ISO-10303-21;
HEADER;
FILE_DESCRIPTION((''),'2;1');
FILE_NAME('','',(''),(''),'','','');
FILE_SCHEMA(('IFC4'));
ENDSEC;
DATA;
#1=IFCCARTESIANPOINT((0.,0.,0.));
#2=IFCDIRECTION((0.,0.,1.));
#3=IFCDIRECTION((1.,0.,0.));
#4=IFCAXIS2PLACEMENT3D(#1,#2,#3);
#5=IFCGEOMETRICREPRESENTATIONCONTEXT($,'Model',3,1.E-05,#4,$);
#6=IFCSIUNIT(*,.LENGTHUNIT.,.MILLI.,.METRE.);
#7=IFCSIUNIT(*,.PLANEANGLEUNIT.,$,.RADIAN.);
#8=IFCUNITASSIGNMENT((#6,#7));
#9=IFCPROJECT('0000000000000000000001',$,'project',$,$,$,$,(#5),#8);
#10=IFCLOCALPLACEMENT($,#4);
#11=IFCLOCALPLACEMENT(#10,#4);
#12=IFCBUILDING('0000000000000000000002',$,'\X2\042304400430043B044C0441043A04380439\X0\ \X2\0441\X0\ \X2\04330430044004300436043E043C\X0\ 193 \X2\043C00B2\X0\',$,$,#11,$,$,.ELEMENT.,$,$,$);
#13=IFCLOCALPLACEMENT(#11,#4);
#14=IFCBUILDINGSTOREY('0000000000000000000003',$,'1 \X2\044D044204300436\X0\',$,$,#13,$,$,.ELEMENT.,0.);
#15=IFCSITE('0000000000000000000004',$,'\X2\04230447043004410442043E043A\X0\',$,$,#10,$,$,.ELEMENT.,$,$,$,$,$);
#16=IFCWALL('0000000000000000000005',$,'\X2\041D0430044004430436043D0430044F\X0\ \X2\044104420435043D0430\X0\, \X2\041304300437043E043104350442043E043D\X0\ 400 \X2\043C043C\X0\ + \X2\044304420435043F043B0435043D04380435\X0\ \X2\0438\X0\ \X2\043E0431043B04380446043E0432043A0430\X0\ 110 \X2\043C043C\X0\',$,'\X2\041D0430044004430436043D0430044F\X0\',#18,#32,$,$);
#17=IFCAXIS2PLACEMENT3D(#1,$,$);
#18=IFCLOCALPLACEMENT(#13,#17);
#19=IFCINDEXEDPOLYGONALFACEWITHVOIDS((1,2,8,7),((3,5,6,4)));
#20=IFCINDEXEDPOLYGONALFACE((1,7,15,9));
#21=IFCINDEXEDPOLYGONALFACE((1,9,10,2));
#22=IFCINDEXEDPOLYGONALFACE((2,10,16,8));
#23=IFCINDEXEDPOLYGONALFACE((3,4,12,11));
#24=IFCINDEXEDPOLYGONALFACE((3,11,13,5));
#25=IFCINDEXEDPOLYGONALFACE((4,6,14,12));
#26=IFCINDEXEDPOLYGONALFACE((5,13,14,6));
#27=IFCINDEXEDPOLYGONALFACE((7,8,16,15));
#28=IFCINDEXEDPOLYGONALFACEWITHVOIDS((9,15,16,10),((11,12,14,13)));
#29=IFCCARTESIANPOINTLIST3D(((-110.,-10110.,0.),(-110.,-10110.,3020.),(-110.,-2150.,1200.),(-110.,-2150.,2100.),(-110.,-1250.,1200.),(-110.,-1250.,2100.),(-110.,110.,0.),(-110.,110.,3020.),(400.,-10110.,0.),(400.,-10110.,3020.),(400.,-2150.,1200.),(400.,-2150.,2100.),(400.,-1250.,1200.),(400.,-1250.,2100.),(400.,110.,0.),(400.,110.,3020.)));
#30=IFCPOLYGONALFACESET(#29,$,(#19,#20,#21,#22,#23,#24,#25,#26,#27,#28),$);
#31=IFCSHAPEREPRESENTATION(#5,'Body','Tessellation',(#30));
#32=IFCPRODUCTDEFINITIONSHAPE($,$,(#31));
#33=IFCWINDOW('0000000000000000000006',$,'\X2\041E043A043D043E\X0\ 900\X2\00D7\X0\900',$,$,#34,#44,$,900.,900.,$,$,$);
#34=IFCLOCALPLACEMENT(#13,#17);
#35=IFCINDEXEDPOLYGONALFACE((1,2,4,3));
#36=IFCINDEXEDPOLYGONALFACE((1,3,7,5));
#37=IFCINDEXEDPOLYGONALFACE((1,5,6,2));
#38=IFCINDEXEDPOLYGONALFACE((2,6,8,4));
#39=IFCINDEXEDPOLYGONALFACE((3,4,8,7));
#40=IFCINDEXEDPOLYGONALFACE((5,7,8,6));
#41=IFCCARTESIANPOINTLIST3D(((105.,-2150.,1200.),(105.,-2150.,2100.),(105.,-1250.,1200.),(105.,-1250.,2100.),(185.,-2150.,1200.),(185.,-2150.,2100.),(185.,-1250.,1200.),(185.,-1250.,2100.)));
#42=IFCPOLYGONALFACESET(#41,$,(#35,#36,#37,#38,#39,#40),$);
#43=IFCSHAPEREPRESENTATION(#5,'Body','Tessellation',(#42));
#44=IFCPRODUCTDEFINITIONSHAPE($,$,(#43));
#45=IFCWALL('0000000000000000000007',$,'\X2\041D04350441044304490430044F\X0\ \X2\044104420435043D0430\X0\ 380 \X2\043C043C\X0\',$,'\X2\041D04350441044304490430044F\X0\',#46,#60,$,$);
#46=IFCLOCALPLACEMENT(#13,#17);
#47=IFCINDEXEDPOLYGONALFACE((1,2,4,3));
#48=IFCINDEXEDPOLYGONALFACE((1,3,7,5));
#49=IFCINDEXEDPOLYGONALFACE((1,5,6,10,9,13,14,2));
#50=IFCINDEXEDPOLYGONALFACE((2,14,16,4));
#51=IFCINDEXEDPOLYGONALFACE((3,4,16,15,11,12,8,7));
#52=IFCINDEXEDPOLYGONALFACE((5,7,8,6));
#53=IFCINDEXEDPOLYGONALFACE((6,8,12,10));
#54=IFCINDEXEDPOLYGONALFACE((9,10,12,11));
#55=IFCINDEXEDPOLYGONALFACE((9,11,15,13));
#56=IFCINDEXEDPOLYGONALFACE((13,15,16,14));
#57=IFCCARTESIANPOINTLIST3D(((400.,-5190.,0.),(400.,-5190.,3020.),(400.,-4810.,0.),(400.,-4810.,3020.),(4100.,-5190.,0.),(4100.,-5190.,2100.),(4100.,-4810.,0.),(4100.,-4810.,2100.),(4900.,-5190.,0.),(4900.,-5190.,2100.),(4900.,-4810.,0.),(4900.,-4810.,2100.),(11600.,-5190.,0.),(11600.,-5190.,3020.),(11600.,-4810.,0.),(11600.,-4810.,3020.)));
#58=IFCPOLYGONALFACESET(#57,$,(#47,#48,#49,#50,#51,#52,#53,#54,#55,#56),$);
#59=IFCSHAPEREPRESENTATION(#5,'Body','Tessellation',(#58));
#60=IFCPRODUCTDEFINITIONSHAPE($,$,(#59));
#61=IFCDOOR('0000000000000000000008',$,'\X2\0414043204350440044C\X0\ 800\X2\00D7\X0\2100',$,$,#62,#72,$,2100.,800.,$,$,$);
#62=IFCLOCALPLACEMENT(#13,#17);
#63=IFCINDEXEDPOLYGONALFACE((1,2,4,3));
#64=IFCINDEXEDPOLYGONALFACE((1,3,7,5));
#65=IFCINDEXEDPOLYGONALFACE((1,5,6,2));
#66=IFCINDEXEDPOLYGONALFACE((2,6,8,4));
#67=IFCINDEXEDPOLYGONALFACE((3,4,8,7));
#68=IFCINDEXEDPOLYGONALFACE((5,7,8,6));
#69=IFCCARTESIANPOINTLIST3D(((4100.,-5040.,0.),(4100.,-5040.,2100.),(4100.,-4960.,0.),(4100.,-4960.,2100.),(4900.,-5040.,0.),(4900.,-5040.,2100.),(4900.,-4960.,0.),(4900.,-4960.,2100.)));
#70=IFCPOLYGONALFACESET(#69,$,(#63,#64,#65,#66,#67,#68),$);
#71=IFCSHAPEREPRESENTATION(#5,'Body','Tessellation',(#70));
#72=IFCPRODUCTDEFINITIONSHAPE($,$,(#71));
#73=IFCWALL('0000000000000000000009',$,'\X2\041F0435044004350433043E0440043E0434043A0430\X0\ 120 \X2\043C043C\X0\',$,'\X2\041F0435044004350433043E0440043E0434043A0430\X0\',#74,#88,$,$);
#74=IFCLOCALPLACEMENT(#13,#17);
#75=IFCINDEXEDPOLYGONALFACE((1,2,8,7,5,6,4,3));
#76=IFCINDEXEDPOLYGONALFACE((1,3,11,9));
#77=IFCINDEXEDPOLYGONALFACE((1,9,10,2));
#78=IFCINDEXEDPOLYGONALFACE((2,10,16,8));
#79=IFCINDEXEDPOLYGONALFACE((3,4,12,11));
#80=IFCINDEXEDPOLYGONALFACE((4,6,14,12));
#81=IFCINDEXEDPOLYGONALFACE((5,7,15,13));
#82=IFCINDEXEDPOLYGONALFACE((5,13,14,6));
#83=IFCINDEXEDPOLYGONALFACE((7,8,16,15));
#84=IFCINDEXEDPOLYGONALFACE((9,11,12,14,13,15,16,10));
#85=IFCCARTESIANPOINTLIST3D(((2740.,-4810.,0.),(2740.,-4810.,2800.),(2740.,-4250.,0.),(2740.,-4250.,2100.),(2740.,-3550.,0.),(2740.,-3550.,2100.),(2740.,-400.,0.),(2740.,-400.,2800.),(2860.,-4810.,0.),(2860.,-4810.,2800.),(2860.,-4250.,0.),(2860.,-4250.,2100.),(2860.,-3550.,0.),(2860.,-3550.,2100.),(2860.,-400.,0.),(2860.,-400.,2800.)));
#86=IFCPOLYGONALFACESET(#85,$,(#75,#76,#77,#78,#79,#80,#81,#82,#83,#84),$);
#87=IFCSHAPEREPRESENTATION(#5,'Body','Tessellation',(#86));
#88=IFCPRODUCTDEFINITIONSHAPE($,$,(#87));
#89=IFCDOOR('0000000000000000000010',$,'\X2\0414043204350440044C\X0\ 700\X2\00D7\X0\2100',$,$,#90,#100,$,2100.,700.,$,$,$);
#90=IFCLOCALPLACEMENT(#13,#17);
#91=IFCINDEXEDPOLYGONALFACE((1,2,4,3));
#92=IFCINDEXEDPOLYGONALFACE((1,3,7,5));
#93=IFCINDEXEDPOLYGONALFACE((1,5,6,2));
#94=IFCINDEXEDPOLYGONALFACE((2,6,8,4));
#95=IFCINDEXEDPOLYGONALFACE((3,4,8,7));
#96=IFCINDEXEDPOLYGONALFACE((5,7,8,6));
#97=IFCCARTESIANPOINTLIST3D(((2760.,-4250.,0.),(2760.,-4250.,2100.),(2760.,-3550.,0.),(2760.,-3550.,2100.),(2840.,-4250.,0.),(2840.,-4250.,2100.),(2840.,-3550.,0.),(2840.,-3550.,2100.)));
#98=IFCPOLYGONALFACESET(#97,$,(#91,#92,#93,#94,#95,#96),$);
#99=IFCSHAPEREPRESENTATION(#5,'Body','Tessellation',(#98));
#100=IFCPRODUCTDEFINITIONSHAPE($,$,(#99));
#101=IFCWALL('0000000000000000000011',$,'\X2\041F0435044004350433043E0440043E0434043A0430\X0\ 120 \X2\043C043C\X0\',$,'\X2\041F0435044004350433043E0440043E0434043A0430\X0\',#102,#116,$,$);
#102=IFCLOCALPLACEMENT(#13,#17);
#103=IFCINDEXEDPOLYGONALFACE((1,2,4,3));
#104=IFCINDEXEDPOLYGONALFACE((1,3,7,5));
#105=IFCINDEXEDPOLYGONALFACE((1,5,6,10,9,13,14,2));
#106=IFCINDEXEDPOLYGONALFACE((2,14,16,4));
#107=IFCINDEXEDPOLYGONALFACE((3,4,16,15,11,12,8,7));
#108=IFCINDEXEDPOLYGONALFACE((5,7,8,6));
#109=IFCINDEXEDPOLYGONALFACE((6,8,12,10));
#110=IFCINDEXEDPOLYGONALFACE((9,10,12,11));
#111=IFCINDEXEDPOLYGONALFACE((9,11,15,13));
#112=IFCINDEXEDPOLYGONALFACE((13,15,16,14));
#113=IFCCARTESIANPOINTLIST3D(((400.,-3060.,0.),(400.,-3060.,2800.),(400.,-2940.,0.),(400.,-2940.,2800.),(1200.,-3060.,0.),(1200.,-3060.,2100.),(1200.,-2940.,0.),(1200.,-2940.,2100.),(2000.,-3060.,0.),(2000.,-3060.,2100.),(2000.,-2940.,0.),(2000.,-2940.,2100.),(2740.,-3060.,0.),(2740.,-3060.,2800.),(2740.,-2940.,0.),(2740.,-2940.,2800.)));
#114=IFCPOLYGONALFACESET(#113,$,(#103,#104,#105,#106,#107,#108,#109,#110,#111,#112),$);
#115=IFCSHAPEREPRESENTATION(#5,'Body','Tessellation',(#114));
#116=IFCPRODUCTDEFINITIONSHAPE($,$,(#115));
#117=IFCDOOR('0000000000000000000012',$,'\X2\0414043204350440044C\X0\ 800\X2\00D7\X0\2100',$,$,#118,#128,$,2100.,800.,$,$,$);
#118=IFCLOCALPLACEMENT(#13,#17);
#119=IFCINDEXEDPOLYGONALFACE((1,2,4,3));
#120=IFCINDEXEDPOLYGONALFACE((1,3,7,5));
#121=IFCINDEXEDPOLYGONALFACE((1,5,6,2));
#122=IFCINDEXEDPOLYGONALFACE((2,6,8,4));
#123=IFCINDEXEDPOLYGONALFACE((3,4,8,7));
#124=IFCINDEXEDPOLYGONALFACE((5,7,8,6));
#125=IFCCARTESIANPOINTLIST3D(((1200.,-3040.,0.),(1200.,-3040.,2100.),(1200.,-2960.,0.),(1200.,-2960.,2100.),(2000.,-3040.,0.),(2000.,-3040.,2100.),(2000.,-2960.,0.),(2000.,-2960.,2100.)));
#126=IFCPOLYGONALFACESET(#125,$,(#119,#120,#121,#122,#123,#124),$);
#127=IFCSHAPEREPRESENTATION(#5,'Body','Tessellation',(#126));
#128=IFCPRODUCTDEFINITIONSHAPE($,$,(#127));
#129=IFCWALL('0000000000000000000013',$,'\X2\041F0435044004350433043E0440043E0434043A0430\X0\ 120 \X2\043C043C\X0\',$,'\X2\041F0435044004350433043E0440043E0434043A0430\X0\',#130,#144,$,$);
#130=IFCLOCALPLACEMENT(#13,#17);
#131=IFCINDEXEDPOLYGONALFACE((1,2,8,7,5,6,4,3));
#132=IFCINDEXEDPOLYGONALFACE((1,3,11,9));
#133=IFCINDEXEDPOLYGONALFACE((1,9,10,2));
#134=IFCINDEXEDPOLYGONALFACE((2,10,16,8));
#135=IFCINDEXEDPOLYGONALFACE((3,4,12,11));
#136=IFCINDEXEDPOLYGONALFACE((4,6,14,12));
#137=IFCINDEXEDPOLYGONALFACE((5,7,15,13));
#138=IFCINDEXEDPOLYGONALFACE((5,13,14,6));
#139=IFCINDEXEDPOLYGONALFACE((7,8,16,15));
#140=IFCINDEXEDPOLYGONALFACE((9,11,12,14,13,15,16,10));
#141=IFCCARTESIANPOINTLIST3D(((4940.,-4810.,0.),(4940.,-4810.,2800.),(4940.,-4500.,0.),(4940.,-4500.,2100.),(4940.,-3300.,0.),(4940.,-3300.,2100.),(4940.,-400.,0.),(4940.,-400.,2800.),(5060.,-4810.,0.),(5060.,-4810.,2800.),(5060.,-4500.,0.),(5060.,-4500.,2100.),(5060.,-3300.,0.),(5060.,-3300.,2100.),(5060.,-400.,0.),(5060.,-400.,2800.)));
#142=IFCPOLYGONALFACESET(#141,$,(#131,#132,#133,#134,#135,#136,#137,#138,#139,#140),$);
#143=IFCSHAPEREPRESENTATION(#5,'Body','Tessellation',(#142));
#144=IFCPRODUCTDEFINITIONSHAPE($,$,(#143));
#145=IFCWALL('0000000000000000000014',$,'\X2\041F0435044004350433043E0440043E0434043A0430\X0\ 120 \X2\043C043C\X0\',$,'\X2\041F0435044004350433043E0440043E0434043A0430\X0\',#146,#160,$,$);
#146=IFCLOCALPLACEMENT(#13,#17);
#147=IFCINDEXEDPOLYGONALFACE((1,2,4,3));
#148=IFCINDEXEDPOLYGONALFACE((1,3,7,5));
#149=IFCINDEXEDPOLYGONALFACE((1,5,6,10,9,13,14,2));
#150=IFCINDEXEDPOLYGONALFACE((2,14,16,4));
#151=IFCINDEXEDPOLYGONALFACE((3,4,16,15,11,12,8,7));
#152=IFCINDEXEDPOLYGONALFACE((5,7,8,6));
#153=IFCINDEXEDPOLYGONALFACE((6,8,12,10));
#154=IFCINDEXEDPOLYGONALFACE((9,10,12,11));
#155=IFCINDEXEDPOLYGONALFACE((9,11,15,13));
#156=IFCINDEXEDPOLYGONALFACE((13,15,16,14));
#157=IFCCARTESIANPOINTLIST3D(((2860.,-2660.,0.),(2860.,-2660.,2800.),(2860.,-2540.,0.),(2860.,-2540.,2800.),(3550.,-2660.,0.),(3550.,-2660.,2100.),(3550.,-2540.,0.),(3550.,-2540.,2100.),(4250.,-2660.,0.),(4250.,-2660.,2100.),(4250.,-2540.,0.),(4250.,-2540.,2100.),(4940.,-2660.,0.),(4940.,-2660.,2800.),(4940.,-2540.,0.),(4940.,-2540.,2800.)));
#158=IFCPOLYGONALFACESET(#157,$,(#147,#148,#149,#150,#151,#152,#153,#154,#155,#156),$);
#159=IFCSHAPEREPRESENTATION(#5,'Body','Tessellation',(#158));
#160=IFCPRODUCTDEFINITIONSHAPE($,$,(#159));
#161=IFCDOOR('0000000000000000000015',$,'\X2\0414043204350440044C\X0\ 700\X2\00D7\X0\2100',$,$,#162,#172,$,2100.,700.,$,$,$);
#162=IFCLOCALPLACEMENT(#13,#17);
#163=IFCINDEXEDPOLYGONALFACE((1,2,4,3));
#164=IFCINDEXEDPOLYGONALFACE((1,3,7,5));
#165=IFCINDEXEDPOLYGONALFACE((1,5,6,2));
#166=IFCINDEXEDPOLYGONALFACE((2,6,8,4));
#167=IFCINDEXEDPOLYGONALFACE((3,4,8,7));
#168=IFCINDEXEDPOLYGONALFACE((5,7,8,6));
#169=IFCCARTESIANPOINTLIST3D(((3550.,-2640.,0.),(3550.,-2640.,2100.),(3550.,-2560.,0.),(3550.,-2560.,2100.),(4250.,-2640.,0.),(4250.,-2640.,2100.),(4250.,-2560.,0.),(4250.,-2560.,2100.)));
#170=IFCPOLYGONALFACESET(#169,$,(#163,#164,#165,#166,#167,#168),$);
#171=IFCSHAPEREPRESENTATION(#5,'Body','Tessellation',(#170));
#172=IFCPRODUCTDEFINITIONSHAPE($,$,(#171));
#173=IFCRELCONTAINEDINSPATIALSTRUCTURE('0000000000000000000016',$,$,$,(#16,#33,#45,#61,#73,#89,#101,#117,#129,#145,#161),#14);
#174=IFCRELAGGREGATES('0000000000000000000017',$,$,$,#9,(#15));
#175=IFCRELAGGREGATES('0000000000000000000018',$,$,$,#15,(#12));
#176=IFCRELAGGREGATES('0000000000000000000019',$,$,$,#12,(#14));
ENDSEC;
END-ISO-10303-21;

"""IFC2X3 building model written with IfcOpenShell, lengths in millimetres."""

from ifc_helpers import new_model, si_unit, frame, frame_2d, origin, origin_with_axes, place, context, project, spatial, rectangle, extrude, element, fill, save


model = new_model("IFC2X3")

# Units and contexts
model_context = context("Model", 3, precision=1e-05, world=origin_with_axes())
ifc_project = project(units=[si_unit("LENGTHUNIT", "METRE", prefix="MILLI"), si_unit("PLANEANGLEUNIT", "RADIAN")], contexts=[model_context])

# Site, building, storey
site_placement = place(None, origin_with_axes())
site = spatial("IfcSite", under=ifc_project, at=site_placement, Name="Участок", CompositionType="ELEMENT")
building_placement = place(site_placement, origin_with_axes())
building = spatial("IfcBuilding", under=site, at=building_placement, Name="Уральский с гаражом 193 м²", CompositionType="ELEMENT")
storey_placement = place(building_placement, origin_with_axes())
storey = spatial("IfcBuildingStorey", under=building, at=storey_placement, Name="1 этаж", CompositionType="ELEMENT", Elevation=0.0)

# Wall, opening, window
wall_1_placement = place(storey_placement, origin_with_axes())
wall_1 = element("IfcWall", 1, at=wall_1_placement, inside=storey, Name="Наружная стена, Газобетон 400 мм + утепление и облицовка 110 мм", ObjectType="Наружная", context=model_context, shape_type="SweptSolid", body=[
    extrude(rectangle(XDim=510.0, YDim=10220.0, at=frame_2d((145.0, -5000.0))), origin(), (0.0, 0.0, 1.0), 3020.0),
])
opening_1_placement = place(storey_placement, origin_with_axes())
opening_1 = element("IfcOpeningElement", 2, at=opening_1_placement, cuts=wall_1, ObjectType="Opening", context=model_context, shape_type="SweptSolid", body=[
    extrude(rectangle(XDim=530.0, YDim=900.0, at=frame_2d((145.0, -1700.0))), frame((0.0, 0.0, 1200.0)), (0.0, 0.0, 1.0), 900.0),
])
window_1_placement = place(storey_placement, origin_with_axes())
window_1 = element("IfcWindow", 3, at=window_1_placement, inside=storey, Name="Окно 900×900", OverallHeight=900.0, OverallWidth=900.0, context=model_context, shape_type="SweptSolid", body=[
    extrude(rectangle(XDim=80.0, YDim=900.0, at=frame_2d((145.0, -1700.0))), frame((0.0, 0.0, 1200.0)), (0.0, 0.0, 1.0), 900.0),
])
fill(opening_1, window_1)

# Walls, openings, doors
wall_2_placement = place(storey_placement, origin_with_axes())
wall_2 = element("IfcWall", 4, at=wall_2_placement, inside=storey, Name="Несущая стена 380 мм", ObjectType="Несущая", context=model_context, shape_type="SweptSolid", body=[
    extrude(rectangle(XDim=11200.0, YDim=380.0, at=frame_2d((6000.0, -5000.0))), origin(), (0.0, 0.0, 1.0), 3020.0),
])
opening_2_placement = place(storey_placement, origin_with_axes())
opening_2 = element("IfcOpeningElement", 5, at=opening_2_placement, cuts=wall_2, ObjectType="Opening", context=model_context, shape_type="SweptSolid", body=[
    extrude(rectangle(XDim=800.0, YDim=400.0, at=frame_2d((4500.0, -5000.0))), origin(), (0.0, 0.0, 1.0), 2100.0),
])
door_1_placement = place(storey_placement, origin_with_axes())
door_1 = element("IfcDoor", 6, at=door_1_placement, inside=storey, Name="Дверь 800×2100", OverallHeight=2100.0, OverallWidth=800.0, context=model_context, shape_type="SweptSolid", body=[
    extrude(rectangle(XDim=800.0, YDim=80.0, at=frame_2d((4500.0, -5000.0))), origin(), (0.0, 0.0, 1.0), 2100.0),
])
fill(opening_2, door_1)
wall_3_placement = place(storey_placement, origin_with_axes())
wall_3 = element("IfcWall", 7, at=wall_3_placement, inside=storey, Name="Перегородка 120 мм", ObjectType="Перегородка", context=model_context, shape_type="SweptSolid", body=[
    extrude(rectangle(XDim=120.0, YDim=4410.0, at=frame_2d((2800.0, -2605.0))), origin(), (0.0, 0.0, 1.0), 2800.0),
])
opening_3_placement = place(storey_placement, origin_with_axes())
opening_3 = element("IfcOpeningElement", 8, at=opening_3_placement, cuts=wall_3, ObjectType="Opening", context=model_context, shape_type="SweptSolid", body=[
    extrude(rectangle(XDim=140.0, YDim=700.0, at=frame_2d((2800.0, -3900.0))), origin(), (0.0, 0.0, 1.0), 2100.0),
])
door_2_placement = place(storey_placement, origin_with_axes())
door_2 = element("IfcDoor", 9, at=door_2_placement, inside=storey, Name="Дверь 700×2100", OverallHeight=2100.0, OverallWidth=700.0, context=model_context, shape_type="SweptSolid", body=[
    extrude(rectangle(XDim=80.0, YDim=700.0, at=frame_2d((2800.0, -3900.0))), origin(), (0.0, 0.0, 1.0), 2100.0),
])
fill(opening_3, door_2)
wall_4_placement = place(storey_placement, origin_with_axes())
wall_4 = element("IfcWall", 10, at=wall_4_placement, inside=storey, Name="Перегородка 120 мм", ObjectType="Перегородка", context=model_context, shape_type="SweptSolid", body=[
    extrude(rectangle(XDim=2340.0, YDim=120.0, at=frame_2d((1570.0, -3000.0))), origin(), (0.0, 0.0, 1.0), 2800.0),
])
opening_4_placement = place(storey_placement, origin_with_axes())
opening_4 = element("IfcOpeningElement", 11, at=opening_4_placement, cuts=wall_4, ObjectType="Opening", context=model_context, shape_type="SweptSolid", body=[
    extrude(rectangle(XDim=800.0, YDim=140.0, at=frame_2d((1600.0, -3000.0))), origin(), (0.0, 0.0, 1.0), 2100.0),
])
door_3_placement = place(storey_placement, origin_with_axes())
door_3 = element("IfcDoor", 12, at=door_3_placement, inside=storey, Name="Дверь 800×2100", OverallHeight=2100.0, OverallWidth=800.0, context=model_context, shape_type="SweptSolid", body=[
    extrude(rectangle(XDim=800.0, YDim=80.0, at=frame_2d((1600.0, -3000.0))), origin(), (0.0, 0.0, 1.0), 2100.0),
])
fill(opening_4, door_3)

# Wall, opening
wall_5_placement = place(storey_placement, origin_with_axes())
wall_5 = element("IfcWall", 13, at=wall_5_placement, inside=storey, Name="Перегородка 120 мм", ObjectType="Перегородка", context=model_context, shape_type="SweptSolid", body=[
    extrude(rectangle(XDim=120.0, YDim=4410.0, at=frame_2d((5000.0, -2605.0))), origin(), (0.0, 0.0, 1.0), 2800.0),
])
opening_5_placement = place(storey_placement, origin_with_axes())
element("IfcOpeningElement", 14, at=opening_5_placement, cuts=wall_5, ObjectType="Opening", context=model_context, shape_type="SweptSolid", body=[
    extrude(rectangle(XDim=140.0, YDim=1200.0, at=frame_2d((5000.0, -3900.0))), origin(), (0.0, 0.0, 1.0), 2100.0),
])

# Wall, opening, door
wall_6_placement = place(storey_placement, origin_with_axes())
wall_6 = element("IfcWall", 15, at=wall_6_placement, inside=storey, Name="Перегородка 120 мм", ObjectType="Перегородка", context=model_context, shape_type="SweptSolid", body=[
    extrude(rectangle(XDim=2080.0, YDim=120.0, at=frame_2d((3900.0, -2600.0))), origin(), (0.0, 0.0, 1.0), 2800.0),
])
opening_6_placement = place(storey_placement, origin_with_axes())
opening_6 = element("IfcOpeningElement", 16, at=opening_6_placement, cuts=wall_6, ObjectType="Opening", context=model_context, shape_type="SweptSolid", body=[
    extrude(rectangle(XDim=700.0, YDim=140.0, at=frame_2d((3900.0, -2600.0))), origin(), (0.0, 0.0, 1.0), 2100.0),
])
door_4_placement = place(storey_placement, origin_with_axes())
door_4 = element("IfcDoor", 17, at=door_4_placement, inside=storey, Name="Дверь 700×2100", OverallHeight=2100.0, OverallWidth=700.0, context=model_context, shape_type="SweptSolid", body=[
    extrude(rectangle(XDim=700.0, YDim=80.0, at=frame_2d((3900.0, -2600.0))), origin(), (0.0, 0.0, 1.0), 2100.0),
])
fill(opening_6, door_4)

save(model, "model.ifc")
